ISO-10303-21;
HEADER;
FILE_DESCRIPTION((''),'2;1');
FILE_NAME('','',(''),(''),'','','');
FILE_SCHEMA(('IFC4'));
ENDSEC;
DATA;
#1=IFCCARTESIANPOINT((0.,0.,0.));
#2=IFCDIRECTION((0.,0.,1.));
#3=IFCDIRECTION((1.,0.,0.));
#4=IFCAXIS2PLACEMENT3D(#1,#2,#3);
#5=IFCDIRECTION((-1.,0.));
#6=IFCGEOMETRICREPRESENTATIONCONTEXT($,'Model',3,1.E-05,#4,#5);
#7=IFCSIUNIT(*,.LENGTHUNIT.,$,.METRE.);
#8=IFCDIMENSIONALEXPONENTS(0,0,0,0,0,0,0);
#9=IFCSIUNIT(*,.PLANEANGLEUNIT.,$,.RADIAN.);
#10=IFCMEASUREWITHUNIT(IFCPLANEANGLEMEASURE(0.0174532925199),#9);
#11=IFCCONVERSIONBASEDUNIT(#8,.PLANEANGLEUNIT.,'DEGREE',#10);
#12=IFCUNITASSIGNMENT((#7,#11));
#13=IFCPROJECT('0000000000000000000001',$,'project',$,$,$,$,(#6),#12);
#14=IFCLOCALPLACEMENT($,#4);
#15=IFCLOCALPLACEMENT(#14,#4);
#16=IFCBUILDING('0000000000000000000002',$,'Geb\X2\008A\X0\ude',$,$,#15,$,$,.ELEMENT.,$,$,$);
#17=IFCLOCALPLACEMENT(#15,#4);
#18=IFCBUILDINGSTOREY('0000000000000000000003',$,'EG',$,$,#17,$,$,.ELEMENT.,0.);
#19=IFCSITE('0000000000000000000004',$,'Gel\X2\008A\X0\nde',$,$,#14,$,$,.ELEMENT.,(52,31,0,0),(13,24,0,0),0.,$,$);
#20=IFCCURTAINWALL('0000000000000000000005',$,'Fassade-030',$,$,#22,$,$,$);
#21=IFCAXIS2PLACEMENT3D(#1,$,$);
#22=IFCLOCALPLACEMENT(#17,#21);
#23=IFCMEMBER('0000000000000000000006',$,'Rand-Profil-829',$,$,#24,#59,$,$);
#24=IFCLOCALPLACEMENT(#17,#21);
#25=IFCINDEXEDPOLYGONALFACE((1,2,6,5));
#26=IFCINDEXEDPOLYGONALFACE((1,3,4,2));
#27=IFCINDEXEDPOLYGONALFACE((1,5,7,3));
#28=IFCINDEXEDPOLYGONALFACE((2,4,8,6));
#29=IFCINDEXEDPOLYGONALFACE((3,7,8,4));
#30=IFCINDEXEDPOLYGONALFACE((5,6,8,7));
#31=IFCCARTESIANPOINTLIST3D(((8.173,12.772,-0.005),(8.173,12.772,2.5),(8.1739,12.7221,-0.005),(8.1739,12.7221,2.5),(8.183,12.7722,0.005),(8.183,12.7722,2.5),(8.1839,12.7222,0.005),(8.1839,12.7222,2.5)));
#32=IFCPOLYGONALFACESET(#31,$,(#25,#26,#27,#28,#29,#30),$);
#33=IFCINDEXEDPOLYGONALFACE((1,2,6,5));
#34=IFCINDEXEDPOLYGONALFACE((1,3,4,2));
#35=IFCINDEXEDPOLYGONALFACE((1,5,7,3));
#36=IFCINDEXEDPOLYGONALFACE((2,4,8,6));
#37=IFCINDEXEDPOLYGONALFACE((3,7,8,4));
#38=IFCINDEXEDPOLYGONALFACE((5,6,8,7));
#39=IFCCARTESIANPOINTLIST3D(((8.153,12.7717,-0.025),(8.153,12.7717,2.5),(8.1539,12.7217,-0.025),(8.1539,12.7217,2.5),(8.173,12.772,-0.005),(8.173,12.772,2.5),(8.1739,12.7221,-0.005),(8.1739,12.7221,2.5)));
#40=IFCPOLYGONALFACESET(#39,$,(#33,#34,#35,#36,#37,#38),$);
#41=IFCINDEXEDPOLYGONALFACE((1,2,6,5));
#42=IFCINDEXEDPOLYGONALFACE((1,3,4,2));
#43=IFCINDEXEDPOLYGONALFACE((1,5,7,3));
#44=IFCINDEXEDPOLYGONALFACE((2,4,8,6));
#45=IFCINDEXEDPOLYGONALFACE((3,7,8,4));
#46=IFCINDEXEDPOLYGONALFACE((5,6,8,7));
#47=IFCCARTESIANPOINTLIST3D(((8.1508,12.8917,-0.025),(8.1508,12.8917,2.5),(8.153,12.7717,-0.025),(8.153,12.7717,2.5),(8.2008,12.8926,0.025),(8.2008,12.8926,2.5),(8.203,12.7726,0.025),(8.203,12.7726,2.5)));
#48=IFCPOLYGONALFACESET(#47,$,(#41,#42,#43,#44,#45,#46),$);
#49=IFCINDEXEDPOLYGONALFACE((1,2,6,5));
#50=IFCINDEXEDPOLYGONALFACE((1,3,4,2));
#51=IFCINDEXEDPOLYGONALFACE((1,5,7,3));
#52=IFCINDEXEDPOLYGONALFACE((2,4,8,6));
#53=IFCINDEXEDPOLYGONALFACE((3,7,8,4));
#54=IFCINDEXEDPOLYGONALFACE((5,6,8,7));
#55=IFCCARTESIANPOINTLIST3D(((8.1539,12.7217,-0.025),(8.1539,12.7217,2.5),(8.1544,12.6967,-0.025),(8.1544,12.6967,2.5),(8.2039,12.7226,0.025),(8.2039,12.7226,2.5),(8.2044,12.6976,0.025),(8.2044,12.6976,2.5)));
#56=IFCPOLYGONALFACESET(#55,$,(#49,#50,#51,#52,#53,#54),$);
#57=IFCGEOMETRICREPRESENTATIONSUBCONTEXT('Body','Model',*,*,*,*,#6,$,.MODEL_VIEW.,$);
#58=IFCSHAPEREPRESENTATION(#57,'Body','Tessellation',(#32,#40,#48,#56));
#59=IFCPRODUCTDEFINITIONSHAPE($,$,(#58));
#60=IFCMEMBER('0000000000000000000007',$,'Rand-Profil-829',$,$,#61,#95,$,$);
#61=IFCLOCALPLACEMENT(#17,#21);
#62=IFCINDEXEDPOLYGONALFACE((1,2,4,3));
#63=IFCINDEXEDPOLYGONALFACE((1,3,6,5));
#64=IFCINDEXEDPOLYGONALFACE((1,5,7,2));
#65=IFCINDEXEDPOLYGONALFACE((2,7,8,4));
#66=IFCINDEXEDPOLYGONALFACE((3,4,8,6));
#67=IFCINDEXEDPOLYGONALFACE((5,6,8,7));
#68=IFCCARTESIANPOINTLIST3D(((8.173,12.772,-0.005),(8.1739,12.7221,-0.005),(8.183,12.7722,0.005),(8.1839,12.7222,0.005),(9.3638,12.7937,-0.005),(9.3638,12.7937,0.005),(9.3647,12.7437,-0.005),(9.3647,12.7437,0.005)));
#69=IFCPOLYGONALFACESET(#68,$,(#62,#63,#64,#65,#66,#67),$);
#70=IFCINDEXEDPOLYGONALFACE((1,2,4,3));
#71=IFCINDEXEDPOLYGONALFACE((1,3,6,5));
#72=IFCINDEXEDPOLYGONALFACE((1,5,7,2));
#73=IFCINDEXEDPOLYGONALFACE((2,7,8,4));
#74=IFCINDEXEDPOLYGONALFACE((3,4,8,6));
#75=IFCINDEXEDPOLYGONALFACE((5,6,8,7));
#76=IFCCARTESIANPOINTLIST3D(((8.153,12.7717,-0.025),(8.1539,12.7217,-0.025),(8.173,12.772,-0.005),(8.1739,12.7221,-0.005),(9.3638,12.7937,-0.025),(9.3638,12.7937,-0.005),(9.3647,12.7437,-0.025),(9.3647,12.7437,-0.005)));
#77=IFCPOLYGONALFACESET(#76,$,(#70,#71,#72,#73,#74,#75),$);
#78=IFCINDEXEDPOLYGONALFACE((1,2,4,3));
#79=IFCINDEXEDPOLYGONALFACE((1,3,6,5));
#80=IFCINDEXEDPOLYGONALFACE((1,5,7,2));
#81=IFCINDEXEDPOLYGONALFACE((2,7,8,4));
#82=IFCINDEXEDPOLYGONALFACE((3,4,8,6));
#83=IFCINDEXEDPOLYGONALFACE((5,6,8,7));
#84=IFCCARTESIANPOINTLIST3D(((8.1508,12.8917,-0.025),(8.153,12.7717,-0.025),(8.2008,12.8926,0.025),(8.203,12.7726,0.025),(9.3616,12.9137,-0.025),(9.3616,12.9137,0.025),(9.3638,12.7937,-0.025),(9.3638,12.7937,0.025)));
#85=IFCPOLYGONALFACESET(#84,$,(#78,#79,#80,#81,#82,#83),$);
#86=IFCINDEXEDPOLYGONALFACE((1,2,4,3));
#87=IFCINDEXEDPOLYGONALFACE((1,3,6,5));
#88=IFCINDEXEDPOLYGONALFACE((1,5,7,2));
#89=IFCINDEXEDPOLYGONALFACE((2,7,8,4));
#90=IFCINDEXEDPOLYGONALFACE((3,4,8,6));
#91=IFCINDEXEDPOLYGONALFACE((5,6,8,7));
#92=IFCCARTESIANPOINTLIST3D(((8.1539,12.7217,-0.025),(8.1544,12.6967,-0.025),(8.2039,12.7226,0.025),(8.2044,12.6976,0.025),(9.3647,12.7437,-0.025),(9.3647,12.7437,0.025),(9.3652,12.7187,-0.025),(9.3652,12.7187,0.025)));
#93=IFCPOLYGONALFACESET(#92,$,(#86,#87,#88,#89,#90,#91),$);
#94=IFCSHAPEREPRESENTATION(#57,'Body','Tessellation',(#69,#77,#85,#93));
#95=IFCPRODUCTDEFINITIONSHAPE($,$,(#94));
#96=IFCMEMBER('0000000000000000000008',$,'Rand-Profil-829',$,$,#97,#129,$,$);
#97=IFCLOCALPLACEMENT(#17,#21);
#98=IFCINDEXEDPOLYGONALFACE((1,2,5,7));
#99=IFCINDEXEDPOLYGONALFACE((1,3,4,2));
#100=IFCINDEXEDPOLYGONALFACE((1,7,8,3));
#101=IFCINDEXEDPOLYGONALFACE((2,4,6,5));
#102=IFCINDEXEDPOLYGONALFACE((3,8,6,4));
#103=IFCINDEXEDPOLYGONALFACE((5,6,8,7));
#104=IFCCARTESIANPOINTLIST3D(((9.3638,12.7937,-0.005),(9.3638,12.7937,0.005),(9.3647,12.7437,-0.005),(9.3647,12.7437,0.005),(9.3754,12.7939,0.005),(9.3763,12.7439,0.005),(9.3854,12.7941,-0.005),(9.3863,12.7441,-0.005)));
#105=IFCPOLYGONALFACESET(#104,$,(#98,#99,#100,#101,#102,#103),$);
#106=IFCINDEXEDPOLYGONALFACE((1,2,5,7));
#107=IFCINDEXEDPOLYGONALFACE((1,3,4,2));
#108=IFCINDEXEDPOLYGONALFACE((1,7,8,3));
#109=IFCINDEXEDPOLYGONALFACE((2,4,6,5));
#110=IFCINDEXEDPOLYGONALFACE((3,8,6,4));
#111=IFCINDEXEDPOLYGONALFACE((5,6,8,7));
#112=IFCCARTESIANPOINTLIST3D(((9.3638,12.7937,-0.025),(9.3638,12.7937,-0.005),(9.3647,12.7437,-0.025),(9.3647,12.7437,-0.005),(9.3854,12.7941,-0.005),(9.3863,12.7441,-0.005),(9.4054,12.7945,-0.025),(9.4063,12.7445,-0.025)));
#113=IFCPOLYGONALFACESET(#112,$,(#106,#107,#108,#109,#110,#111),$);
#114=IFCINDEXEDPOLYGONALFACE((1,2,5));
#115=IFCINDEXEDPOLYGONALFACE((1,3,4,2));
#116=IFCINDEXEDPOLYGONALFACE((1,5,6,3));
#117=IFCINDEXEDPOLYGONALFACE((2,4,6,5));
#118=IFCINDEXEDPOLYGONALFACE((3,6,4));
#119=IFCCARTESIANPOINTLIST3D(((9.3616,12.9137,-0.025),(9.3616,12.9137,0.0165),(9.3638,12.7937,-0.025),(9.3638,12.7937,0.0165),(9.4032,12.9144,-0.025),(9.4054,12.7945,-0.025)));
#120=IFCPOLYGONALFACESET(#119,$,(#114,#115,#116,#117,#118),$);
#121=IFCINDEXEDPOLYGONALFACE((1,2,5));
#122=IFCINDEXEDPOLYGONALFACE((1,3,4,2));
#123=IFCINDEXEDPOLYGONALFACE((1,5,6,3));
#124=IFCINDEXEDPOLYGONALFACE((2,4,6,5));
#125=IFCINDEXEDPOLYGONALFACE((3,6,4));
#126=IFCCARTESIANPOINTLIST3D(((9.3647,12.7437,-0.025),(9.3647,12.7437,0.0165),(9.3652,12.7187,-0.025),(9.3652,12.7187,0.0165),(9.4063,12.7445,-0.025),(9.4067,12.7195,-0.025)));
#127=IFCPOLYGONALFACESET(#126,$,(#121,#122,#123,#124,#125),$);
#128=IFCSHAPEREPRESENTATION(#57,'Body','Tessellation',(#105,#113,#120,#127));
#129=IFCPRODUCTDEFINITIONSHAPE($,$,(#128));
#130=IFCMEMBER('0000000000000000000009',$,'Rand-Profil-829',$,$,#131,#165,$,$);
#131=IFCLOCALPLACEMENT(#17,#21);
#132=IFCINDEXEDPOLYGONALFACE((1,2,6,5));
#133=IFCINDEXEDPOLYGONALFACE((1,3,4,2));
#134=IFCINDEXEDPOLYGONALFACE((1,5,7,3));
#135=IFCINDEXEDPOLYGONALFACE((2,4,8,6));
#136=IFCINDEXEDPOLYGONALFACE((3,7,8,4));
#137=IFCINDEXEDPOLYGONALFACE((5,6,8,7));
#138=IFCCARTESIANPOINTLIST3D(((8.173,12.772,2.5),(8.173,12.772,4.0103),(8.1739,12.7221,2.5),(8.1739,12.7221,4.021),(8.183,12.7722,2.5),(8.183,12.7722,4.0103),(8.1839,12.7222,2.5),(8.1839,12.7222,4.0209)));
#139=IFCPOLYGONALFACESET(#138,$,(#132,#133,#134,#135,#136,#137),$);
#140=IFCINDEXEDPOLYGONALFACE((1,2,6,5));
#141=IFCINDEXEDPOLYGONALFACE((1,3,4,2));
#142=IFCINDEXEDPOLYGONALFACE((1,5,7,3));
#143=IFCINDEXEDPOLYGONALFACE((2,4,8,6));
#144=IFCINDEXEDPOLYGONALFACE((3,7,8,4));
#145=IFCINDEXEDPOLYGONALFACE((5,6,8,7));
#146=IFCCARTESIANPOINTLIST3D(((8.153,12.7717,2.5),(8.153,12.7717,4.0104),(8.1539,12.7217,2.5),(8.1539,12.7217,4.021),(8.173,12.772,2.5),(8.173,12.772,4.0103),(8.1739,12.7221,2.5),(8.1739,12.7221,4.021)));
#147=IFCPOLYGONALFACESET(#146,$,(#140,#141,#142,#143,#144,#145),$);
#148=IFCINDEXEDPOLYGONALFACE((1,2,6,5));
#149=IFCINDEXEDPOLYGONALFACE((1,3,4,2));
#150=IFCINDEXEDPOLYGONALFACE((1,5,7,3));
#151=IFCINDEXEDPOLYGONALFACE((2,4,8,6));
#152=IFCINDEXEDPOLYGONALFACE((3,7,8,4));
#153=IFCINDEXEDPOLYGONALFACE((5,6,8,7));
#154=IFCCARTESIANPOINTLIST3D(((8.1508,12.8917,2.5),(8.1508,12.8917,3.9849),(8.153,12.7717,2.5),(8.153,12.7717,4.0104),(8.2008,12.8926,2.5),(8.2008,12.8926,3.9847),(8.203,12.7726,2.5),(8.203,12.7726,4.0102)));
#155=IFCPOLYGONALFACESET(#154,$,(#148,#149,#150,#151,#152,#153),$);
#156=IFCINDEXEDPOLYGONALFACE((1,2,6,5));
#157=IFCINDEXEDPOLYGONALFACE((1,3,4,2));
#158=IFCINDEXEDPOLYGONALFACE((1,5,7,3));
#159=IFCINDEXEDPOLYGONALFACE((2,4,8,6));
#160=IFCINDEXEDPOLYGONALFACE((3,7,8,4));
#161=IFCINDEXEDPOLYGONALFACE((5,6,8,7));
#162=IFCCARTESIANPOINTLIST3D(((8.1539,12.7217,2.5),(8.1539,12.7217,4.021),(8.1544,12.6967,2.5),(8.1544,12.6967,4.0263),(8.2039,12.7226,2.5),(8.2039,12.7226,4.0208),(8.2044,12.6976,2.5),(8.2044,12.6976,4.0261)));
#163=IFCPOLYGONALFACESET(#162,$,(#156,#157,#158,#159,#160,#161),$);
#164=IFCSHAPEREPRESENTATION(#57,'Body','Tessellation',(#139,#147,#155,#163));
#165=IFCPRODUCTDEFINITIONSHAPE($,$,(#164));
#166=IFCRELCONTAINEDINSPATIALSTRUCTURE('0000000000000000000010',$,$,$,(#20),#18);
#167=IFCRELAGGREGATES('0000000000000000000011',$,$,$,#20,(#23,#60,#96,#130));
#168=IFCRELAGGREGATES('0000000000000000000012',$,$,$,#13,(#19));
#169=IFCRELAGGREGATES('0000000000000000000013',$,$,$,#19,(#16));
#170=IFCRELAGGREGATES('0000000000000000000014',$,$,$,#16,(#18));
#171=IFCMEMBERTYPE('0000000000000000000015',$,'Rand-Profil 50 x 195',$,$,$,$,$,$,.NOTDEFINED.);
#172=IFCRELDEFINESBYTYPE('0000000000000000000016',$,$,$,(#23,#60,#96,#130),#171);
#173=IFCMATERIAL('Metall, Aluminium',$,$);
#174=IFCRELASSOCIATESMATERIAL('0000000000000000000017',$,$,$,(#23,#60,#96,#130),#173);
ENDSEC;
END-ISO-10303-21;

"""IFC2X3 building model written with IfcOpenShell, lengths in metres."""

from ifc_helpers import new_model, entity, si_unit, converted_unit, direction, frame, origin_with_axes, place, context, subcontext, project, spatial, polyline, outline, extrude, clip, halfspace, material, type_object, element, aggregate, save


model = new_model("IFC2X3")

# Units and contexts
model_context = context("Model", 3, precision=1e-05, world=origin_with_axes(), true_north=direction((-1.0, 0.0)))
body_context = subcontext(model_context, "Body", "Model", "MODEL_VIEW")
ifc_project = project(units=[si_unit("LENGTHUNIT", "METRE"), converted_unit("PLANEANGLEUNIT", "DEGREE", entity("IfcPlaneAngleMeasure", 0.0174532925199), si_unit("PLANEANGLEUNIT", "RADIAN"), dimensions=[0, 0, 0, 0, 0, 0, 0])], contexts=[model_context])

# Site, building, storey
site_placement = place(None, origin_with_axes())
site = spatial("IfcSite", under=ifc_project, at=site_placement, Name="Gel\u008ande", CompositionType="ELEMENT", RefLatitude=(52, 31, 0, 0), RefLongitude=(13, 24, 0, 0), RefElevation=0.0)
building_placement = place(site_placement, origin_with_axes())
building = spatial("IfcBuilding", under=site, at=building_placement, Name="Geb\u008aude", CompositionType="ELEMENT")
storey_placement = place(building_placement, origin_with_axes())
storey = spatial("IfcBuildingStorey", under=building, at=storey_placement, Name="EG", CompositionType="ELEMENT", Elevation=0.0)

# Curtain wall
curtain_wall_1_placement = place(storey_placement, frame((8.7714, 12.7579, 0.0), z_axis=(0.0, 0.0, 1.0), x_axis=(1.0, 0.0, 0.0)))
curtain_wall_1 = element("IfcCurtainWall", 1, at=curtain_wall_1_placement, inside=storey, Name="Fassade-030")
ifc_material_1 = material(Name="Metall, Aluminium")

# Members
member_type_1 = type_object("IfcMemberType", Name="Rand-Profil 50 x 195", PredefinedType="NOTDEFINED")
member_1_placement = place(curtain_wall_1_placement, frame((-0.5929, -0.0108, 0.0), z_axis=(0.0, 0.0, 1.0), x_axis=(-0.999835, -0.018178, 0.0)))
member_1 = element("IfcMember", 2, at=member_1_placement, type_object=member_type_1, material=ifc_material_1, Name="Rand-Profil-829", context=body_context, shape_type="Clipping", body=[
    clip(extrude(outline(polyline([(-0.0055, 0.0249), (-0.0045, -0.0251), (0.0055, -0.0249), (0.0045, 0.0251), (-0.0055, 0.0249)])), frame((0.0, 0.0, -0.005), z_axis=(0.0, 0.0, 1.0), x_axis=(-0.999835, 0.018178, 0.0)), (0.0, 0.0, 1.0), 2.505), halfspace(frame((0.0, 0.0, 0.0), z_axis=(0.707107, 0.0, 0.707107), x_axis=(-0.707107, 0.0, 0.707107)), True)),
    clip(extrude(outline(polyline([(-0.0255, 0.0245), (-0.0245, -0.0255), (-0.0045, -0.0251), (-0.0055, 0.0249), (-0.0255, 0.0245)])), frame((0.0, 0.0, -0.025), z_axis=(0.0, 0.0, 1.0), x_axis=(-0.999835, 0.018178, 0.0)), (0.0, 0.0, 1.0), 2.525), halfspace(frame((0.0, 0.0, 0.0), z_axis=(0.707107, 0.0, 0.707107), x_axis=(-0.707107, 0.0, 0.707107)), True)),
    clip(extrude(outline(polyline([(-0.0276, 0.1445), (-0.0255, 0.0245), (0.0245, 0.0255), (0.0224, 0.1454), (-0.0276, 0.1445)])), frame((0.0, 0.0, -0.025), z_axis=(0.0, 0.0, 1.0), x_axis=(-0.999835, 0.018178, 0.0)), (0.0, 0.0, 1.0), 2.525), halfspace(frame((0.0, 0.0, 0.0), z_axis=(0.707107, 0.0, 0.707107), x_axis=(-0.707107, 0.0, 0.707107)), True)),
    clip(extrude(outline(polyline([(0.0259, -0.0495), (0.0255, -0.0245), (-0.0245, -0.0255), (-0.0241, -0.0504), (0.0259, -0.0495)])), frame((0.0, 0.0, -0.025), z_axis=(0.0, 0.0, 1.0), x_axis=(-0.999835, 0.018178, 0.0)), (0.0, 0.0, 1.0), 2.525), halfspace(frame((0.0, 0.0, 0.0), z_axis=(0.707107, 0.0, 0.707107), x_axis=(-0.707107, 0.0, 0.707107)), True)),
])
member_2_placement = place(curtain_wall_1_placement, frame((-0.5929, -0.0108, 0.0), z_axis=(0.999835, 0.018178, 0.0), x_axis=(0.0, 0.0, 1.0)))
member_2 = element("IfcMember", 3, at=member_2_placement, type_object=member_type_1, material=ifc_material_1, Name="Rand-Profil-829", context=body_context, shape_type="Clipping", body=[
    clip(extrude(outline(polyline([(-0.025, -0.005), (0.025, -0.005), (0.025, 0.005), (-0.025, 0.005), (-0.025, -0.005)])), frame((0.0, 0.0, -0.005), z_axis=(0.0, 0.0, 1.0), x_axis=(0.0, 1.0, 0.0)), (0.0, 0.0, 1.0), 1.191), halfspace(frame((0.0, 0.0, 0.0), z_axis=(-0.707107, 0.0, 0.707107), x_axis=(-0.707107, 0.0, -0.707107)), True)),
    clip(extrude(outline(polyline([(-0.025, 0.005), (0.025, 0.005), (0.025, 0.025), (-0.025, 0.025), (-0.025, 0.005)])), frame((0.0, 0.0, -0.025), z_axis=(0.0, 0.0, 1.0), x_axis=(0.0, 1.0, 0.0)), (0.0, 0.0, 1.0), 1.211), halfspace(frame((0.0, 0.0, 0.0), z_axis=(-0.707107, 0.0, 0.707107), x_axis=(-0.707107, 0.0, -0.707107)), True)),
    clip(extrude(outline(polyline([(-0.145, -0.025), (-0.025, -0.025), (-0.025, 0.025), (-0.145, 0.025), (-0.145, -0.025)])), frame((0.0, 0.0, -0.025), z_axis=(0.0, 0.0, 1.0), x_axis=(0.0, 1.0, 0.0)), (0.0, 0.0, 1.0), 1.211), halfspace(frame((0.0, 0.0, 0.0), z_axis=(-0.707107, 0.0, 0.707107), x_axis=(-0.707107, 0.0, -0.707107)), True)),
    clip(extrude(outline(polyline([(0.05, 0.025), (0.025, 0.025), (0.025, -0.025), (0.05, -0.025), (0.05, 0.025)])), frame((0.0, 0.0, -0.025), z_axis=(0.0, 0.0, 1.0), x_axis=(0.0, 1.0, 0.0)), (0.0, 0.0, 1.0), 1.211), halfspace(frame((0.0, 0.0, 0.0), z_axis=(-0.707107, 0.0, 0.707107), x_axis=(-0.707107, 0.0, -0.707107)), True)),
])
member_3_placement = place(curtain_wall_1_placement, frame((0.5929, 0.0108, 0.0), z_axis=(0.999835, 0.018178, 0.0), x_axis=(0.0, 0.0, 1.0)))
member_3 = element("IfcMember", 4, at=member_3_placement, type_object=member_type_1, material=ifc_material_1, Name="Rand-Profil-829", context=body_context, shape_type="Clipping", body=[
    clip(extrude(outline(polyline([(-0.025, -0.005), (0.025, -0.005), (0.025, 0.005), (-0.025, 0.005), (-0.025, -0.005)])), frame((0.0, 0.0, 0.0), z_axis=(0.0, 0.0, 1.0), x_axis=(0.0, 1.0, 0.0)), (0.0, 0.0, 1.0), 0.0215), halfspace(frame((0.0083, 0.0, 0.0083), z_axis=(-0.707107, 0.0, -0.707107), x_axis=(0.707107, 0.0, -0.707107)), True)),
    clip(extrude(outline(polyline([(-0.025, 0.005), (0.025, 0.005), (0.025, 0.025), (-0.025, 0.025), (-0.025, 0.005)])), frame((0.0, 0.0, 0.0), z_axis=(0.0, 0.0, 1.0), x_axis=(0.0, 1.0, 0.0)), (0.0, 0.0, 1.0), 0.0415), halfspace(frame((0.0083, 0.0, 0.0083), z_axis=(-0.707107, 0.0, -0.707107), x_axis=(0.707107, 0.0, -0.707107)), True)),
    clip(extrude(outline(polyline([(-0.025, -0.0165), (-0.025, 0.025), (-0.145, 0.025), (-0.145, -0.0165), (-0.025, -0.0165)])), frame((0.0, 0.0, 0.0), z_axis=(0.0, 0.0, 1.0), x_axis=(0.0, 1.0, 0.0)), (0.0, 0.0, 1.0), 0.0415), halfspace(frame((0.0083, 0.0, 0.0083), z_axis=(-0.707107, 0.0, -0.707107), x_axis=(0.707107, 0.0, -0.707107)), True)),
    clip(extrude(outline(polyline([(0.025, -0.0165), (0.05, -0.0165), (0.05, 0.025), (0.025, 0.025), (0.025, -0.0165)])), frame((0.0, 0.0, 0.0), z_axis=(0.0, 0.0, 1.0), x_axis=(0.0, 1.0, 0.0)), (0.0, 0.0, 1.0), 0.0415), halfspace(frame((0.0083, 0.0, 0.0083), z_axis=(-0.707107, 0.0, -0.707107), x_axis=(0.707107, 0.0, -0.707107)), True)),
])
member_4_placement = place(curtain_wall_1_placement, frame((-0.5929, -0.0108, 2.5), z_axis=(0.0, 0.0, 1.0), x_axis=(-0.999835, -0.018178, 0.0)))
member_4 = element("IfcMember", 5, at=member_4_placement, type_object=member_type_1, material=ifc_material_1, Name="Rand-Profil-829", context=body_context, shape_type="Clipping", body=[
    clip(extrude(outline(polyline([(0.0055, -0.0249), (0.0045, 0.0251), (-0.0055, 0.0249), (-0.0045, -0.0251), (0.0055, -0.0249)])), frame((0.0, 0.0, 0.0), z_axis=(0.0, 0.0, 1.0), x_axis=(-0.999835, 0.018178, 0.0)), (0.0, 0.0, 1.0), 1.521), halfspace(frame((-0.0056, -0.3082, 1.4501), z_axis=(0.003779, 0.207877, -0.978148), x_axis=(0.0, -0.978155, -0.207879)), True)),
    clip(extrude(outline(polyline([(-0.0045, -0.0251), (-0.0055, 0.0249), (-0.0255, 0.0245), (-0.0245, -0.0255), (-0.0045, -0.0251)])), frame((0.0, 0.0, 0.0), z_axis=(0.0, 0.0, 1.0), x_axis=(-0.999835, 0.018178, 0.0)), (0.0, 0.0, 1.0), 1.521), halfspace(frame((-0.0056, -0.3082, 1.4501), z_axis=(0.003779, 0.207877, -0.978148), x_axis=(0.0, -0.978155, -0.207879)), True)),
    clip(extrude(outline(polyline([(0.0245, 0.0255), (0.0224, 0.1454), (-0.0276, 0.1445), (-0.0255, 0.0245), (0.0245, 0.0255)])), frame((0.0, 0.0, 0.0), z_axis=(0.0, 0.0, 1.0), x_axis=(-0.999835, 0.018178, 0.0)), (0.0, 0.0, 1.0), 1.5104), halfspace(frame((-0.0056, -0.3082, 1.4501), z_axis=(0.003779, 0.207877, -0.978148), x_axis=(0.0, -0.978155, -0.207879)), True)),
    clip(extrude(outline(polyline([(0.0259, -0.0495), (0.0255, -0.0245), (-0.0245, -0.0255), (-0.0241, -0.0504), (0.0259, -0.0495)])), frame((0.0, 0.0, 0.0), z_axis=(0.0, 0.0, 1.0), x_axis=(-0.999835, 0.018178, 0.0)), (0.0, 0.0, 1.0), 1.5263), halfspace(frame((-0.0056, -0.3082, 1.4501), z_axis=(0.003779, 0.207877, -0.978148), x_axis=(0.0, -0.978155, -0.207879)), True)),
])

aggregate(curtain_wall_1, [member_1, member_2, member_3, member_4])

save(model, "model.ifc")
